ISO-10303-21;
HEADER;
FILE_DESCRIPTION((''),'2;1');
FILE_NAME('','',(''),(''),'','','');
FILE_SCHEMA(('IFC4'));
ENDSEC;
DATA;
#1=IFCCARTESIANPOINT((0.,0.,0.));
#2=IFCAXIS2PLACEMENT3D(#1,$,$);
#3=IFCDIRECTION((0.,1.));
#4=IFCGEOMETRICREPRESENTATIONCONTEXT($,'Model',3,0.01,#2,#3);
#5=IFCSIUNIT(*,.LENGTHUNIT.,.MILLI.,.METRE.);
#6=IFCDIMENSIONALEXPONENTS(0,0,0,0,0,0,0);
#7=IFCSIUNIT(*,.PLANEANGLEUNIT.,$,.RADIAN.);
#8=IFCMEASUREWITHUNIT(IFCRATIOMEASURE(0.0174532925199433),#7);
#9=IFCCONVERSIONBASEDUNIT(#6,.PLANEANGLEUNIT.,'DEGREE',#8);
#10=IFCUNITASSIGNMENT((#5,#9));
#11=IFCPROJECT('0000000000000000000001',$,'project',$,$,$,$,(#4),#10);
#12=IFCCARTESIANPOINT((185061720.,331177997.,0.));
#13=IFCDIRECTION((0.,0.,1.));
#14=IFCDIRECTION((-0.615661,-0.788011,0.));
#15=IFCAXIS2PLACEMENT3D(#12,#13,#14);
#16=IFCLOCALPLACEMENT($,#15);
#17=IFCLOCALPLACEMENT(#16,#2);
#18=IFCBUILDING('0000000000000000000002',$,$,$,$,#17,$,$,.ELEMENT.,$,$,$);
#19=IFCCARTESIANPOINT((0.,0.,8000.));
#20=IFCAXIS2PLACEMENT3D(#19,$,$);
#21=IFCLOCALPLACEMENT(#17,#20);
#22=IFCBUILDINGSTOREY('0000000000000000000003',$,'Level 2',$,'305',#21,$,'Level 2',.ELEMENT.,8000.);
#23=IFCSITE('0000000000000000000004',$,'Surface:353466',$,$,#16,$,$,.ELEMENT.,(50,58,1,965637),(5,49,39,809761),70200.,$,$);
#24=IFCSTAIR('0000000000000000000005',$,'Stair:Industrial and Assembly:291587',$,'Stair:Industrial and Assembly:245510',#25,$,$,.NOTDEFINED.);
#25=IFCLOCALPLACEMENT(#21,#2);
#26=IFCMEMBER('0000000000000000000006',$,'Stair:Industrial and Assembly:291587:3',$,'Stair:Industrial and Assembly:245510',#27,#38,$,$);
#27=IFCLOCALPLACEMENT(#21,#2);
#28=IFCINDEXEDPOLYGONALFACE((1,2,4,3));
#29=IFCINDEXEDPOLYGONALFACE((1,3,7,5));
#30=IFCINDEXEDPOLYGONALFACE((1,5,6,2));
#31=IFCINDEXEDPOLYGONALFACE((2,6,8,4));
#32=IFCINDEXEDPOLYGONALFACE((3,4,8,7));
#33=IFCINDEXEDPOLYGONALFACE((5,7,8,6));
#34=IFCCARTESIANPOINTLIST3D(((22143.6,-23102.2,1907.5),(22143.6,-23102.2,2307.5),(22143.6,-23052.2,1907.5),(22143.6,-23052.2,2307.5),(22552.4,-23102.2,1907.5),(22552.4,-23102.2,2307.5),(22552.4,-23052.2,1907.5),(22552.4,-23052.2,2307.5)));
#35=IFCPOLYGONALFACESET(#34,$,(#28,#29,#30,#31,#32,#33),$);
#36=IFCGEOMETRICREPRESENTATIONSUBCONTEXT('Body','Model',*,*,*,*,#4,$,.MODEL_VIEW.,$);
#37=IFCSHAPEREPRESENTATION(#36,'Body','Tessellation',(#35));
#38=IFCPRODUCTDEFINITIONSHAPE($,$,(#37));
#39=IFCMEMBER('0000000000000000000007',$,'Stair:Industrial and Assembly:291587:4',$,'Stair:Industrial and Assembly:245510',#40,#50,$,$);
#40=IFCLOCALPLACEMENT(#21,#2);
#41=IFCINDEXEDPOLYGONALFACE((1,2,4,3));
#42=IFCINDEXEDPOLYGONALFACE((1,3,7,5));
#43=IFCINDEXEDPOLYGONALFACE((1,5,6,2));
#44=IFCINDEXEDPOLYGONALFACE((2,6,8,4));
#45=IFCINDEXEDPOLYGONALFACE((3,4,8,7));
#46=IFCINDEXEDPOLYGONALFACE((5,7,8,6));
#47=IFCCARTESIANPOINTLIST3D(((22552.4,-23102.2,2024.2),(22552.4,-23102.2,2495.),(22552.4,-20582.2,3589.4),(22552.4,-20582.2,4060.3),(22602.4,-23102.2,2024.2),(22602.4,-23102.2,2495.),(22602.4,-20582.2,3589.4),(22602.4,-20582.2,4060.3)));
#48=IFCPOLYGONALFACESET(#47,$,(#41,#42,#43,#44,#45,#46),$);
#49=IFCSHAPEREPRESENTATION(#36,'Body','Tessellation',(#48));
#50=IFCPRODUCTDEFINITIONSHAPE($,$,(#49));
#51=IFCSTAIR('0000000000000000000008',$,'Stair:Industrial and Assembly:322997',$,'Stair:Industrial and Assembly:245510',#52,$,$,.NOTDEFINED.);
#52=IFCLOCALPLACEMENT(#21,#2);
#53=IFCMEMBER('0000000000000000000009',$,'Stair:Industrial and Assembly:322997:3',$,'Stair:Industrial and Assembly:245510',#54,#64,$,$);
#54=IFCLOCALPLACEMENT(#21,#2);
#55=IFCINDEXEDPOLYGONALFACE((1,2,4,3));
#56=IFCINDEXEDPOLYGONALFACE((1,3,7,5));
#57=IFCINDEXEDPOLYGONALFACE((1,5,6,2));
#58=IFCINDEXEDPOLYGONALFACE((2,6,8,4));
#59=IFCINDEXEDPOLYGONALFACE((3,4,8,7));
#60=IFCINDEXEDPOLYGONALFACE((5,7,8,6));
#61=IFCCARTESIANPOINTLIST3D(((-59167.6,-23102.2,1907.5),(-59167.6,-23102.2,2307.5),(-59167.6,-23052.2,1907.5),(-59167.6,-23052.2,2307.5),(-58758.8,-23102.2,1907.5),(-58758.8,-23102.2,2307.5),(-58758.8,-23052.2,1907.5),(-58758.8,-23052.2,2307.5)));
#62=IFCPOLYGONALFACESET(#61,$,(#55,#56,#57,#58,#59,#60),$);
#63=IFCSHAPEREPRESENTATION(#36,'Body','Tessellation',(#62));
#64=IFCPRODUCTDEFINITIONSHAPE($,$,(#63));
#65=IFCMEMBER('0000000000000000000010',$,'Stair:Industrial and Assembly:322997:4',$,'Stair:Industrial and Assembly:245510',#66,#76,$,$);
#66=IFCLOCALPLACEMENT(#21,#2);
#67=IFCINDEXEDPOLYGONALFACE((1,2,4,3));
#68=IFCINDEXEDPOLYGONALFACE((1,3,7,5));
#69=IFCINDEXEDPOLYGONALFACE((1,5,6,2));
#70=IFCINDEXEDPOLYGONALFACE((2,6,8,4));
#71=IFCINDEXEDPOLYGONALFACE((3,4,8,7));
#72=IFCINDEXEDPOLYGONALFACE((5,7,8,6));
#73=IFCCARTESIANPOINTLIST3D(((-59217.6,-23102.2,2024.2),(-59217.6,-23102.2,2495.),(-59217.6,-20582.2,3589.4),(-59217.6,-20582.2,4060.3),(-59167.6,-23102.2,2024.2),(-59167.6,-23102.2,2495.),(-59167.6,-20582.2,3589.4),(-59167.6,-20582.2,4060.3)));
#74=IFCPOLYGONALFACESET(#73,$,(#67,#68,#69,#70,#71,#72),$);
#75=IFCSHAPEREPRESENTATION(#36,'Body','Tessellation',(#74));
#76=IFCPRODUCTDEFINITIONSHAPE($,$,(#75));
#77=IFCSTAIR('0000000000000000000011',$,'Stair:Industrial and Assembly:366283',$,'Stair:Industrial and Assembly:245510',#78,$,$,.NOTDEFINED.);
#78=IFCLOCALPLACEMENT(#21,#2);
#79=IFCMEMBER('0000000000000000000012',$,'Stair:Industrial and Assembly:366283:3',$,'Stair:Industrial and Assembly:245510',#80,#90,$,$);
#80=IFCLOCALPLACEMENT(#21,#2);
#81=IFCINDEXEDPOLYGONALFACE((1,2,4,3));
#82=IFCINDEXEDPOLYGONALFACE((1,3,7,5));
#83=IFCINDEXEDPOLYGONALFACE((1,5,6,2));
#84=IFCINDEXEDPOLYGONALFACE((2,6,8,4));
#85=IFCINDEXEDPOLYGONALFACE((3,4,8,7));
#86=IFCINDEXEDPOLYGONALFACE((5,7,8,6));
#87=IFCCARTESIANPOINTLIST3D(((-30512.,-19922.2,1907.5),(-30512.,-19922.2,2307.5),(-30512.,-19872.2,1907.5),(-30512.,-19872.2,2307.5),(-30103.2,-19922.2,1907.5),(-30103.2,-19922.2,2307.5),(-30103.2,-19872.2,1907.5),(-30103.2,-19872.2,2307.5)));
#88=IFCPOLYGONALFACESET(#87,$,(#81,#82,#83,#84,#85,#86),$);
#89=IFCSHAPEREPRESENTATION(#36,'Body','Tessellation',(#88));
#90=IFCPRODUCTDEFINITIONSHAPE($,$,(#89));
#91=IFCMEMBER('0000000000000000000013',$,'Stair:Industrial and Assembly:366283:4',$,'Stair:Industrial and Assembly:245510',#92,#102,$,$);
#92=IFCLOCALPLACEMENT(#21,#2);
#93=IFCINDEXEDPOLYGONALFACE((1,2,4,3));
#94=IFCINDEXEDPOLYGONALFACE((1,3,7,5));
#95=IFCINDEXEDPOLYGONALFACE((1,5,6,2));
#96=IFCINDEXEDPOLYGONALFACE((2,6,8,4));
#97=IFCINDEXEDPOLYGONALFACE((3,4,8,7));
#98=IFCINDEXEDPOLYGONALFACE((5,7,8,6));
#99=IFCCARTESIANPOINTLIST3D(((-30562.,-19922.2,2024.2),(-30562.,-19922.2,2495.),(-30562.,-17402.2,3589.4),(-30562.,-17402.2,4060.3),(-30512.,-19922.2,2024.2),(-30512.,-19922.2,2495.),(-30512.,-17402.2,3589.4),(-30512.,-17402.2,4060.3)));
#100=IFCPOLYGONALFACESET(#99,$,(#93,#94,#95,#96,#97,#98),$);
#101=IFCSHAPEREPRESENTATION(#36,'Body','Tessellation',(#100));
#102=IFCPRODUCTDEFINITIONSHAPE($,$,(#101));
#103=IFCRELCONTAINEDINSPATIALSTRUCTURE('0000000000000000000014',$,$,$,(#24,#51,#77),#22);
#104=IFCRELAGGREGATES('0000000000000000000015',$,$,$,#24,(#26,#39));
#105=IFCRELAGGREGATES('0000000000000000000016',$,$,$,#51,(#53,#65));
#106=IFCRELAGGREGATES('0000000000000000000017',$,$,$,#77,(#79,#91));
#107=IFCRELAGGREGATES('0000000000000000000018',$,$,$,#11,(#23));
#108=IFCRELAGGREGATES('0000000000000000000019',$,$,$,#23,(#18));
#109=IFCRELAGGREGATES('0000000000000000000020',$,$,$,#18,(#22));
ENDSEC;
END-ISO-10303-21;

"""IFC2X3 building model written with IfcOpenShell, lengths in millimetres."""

from ifc_helpers import new_model, entity, si_unit, converted_unit, direction, frame, frame_2d, origin, place, context, subcontext, project, spatial, polyline, rectangle, outline, extrude, element, aggregate, save


model = new_model("IFC2X3")

# Units and contexts
model_context = context("Model", 3, precision=0.01, world=origin(), true_north=direction((0.0, 1.0)))
body_context = subcontext(model_context, "Body", "Model", "MODEL_VIEW")
ifc_project = project(units=[si_unit("LENGTHUNIT", "METRE", prefix="MILLI"), converted_unit("PLANEANGLEUNIT", "DEGREE", entity("IfcRatioMeasure", 0.0174532925199433), si_unit("PLANEANGLEUNIT", "RADIAN"), dimensions=[0, 0, 0, 0, 0, 0, 0])], contexts=[model_context])

# Site, building, storey
site_placement = place(None, frame((185061720.0, 331177997.0, 0.0), z_axis=(0.0, 0.0, 1.0), x_axis=(-0.615661, -0.788011, 0.0)))
site = spatial("IfcSite", under=ifc_project, at=site_placement, Name="Surface:353466", CompositionType="ELEMENT", RefLatitude=(50, 58, 1, 965637), RefLongitude=(5, 49, 39, 809761), RefElevation=70200.0)
building_placement = place(site_placement, origin())
building = spatial("IfcBuilding", under=site, at=building_placement, CompositionType="ELEMENT")
storey_placement = place(building_placement, frame((0.0, 0.0, 8000.0)))
storey = spatial("IfcBuildingStorey", under=building, at=storey_placement, Name="Level 2", ObjectType="305", LongName="Level 2", CompositionType="ELEMENT", Elevation=8000.0)

# Stairs, members
stair_1_placement = place(storey_placement, origin())
stair_1 = element("IfcStair", 1, at=stair_1_placement, inside=storey, Name="Stair:Industrial and Assembly:291587", ObjectType="Stair:Industrial and Assembly:245510", ShapeType="NOTDEFINED")
member_1_placement = place(stair_1_placement, origin())
member_1 = element("IfcMember", 2, at=member_1_placement, Name="Stair:Industrial and Assembly:291587:3", ObjectType="Stair:Industrial and Assembly:245510", context=body_context, shape_type="SweptSolid", body=[
    extrude(rectangle(XDim=408.8, YDim=50.0, at=frame_2d((0.0, 0.0), x_axis=(1.0, 0.0))), frame((22348.0, -23077.2, 1907.5)), (0.0, 0.0, 1.0), 400.0),
])
member_2_placement = place(stair_1_placement, origin())
member_2 = element("IfcMember", 3, at=member_2_placement, Name="Stair:Industrial and Assembly:291587:4", ObjectType="Stair:Industrial and Assembly:245510", context=body_context, shape_type="SweptSolid", body=[
    extrude(outline(polyline([(-1607.5, -200.0), (1359.0, -200.0), (1607.5, 200.0), (-1359.0, 200.0), (-1607.5, -200.0)])), frame((22552.4, -21842.2, 3042.2), z_axis=(1.0, 0.0, 0.0), x_axis=(0.0, 0.849477, 0.527626)), (0.0, 0.0, 1.0), 50.0),
])
stair_2_placement = place(storey_placement, origin())
stair_2 = element("IfcStair", 4, at=stair_2_placement, inside=storey, Name="Stair:Industrial and Assembly:322997", ObjectType="Stair:Industrial and Assembly:245510", ShapeType="NOTDEFINED")
member_3_placement = place(stair_2_placement, origin())
member_3 = element("IfcMember", 5, at=member_3_placement, Name="Stair:Industrial and Assembly:322997:3", ObjectType="Stair:Industrial and Assembly:245510", context=body_context, shape_type="SweptSolid", body=[
    extrude(rectangle(XDim=408.8, YDim=50.0, at=frame_2d((0.0, 0.0), x_axis=(1.0, 0.0))), frame((-58963.2, -23077.2, 1907.5), z_axis=(0.0, 0.0, 1.0), x_axis=(-1.0, 0.0, 0.0)), (0.0, 0.0, 1.0), 400.0),
])
member_4_placement = place(stair_2_placement, origin())
member_4 = element("IfcMember", 6, at=member_4_placement, Name="Stair:Industrial and Assembly:322997:4", ObjectType="Stair:Industrial and Assembly:245510", context=body_context, shape_type="SweptSolid", body=[
    extrude(outline(polyline([(-1607.5, -200.0), (1359.0, -200.0), (1607.5, 200.0), (-1359.0, 200.0), (-1607.5, -200.0)])), frame((-59217.6, -21842.2, 3042.2), z_axis=(1.0, 0.0, 0.0), x_axis=(0.0, 0.849477, 0.527626)), (0.0, 0.0, 1.0), 50.0),
])
stair_3_placement = place(storey_placement, origin())
stair_3 = element("IfcStair", 7, at=stair_3_placement, inside=storey, Name="Stair:Industrial and Assembly:366283", ObjectType="Stair:Industrial and Assembly:245510", ShapeType="NOTDEFINED")
member_5_placement = place(stair_3_placement, origin())
member_5 = element("IfcMember", 8, at=member_5_placement, Name="Stair:Industrial and Assembly:366283:3", ObjectType="Stair:Industrial and Assembly:245510", context=body_context, shape_type="SweptSolid", body=[
    extrude(rectangle(XDim=408.8, YDim=50.0, at=frame_2d((0.0, 0.0), x_axis=(1.0, 0.0))), frame((-30307.6, -19897.2, 1907.5), z_axis=(0.0, 0.0, 1.0), x_axis=(-1.0, 0.0, 0.0)), (0.0, 0.0, 1.0), 400.0),
])
member_6_placement = place(stair_3_placement, origin())
member_6 = element("IfcMember", 9, at=member_6_placement, Name="Stair:Industrial and Assembly:366283:4", ObjectType="Stair:Industrial and Assembly:245510", context=body_context, shape_type="SweptSolid", body=[
    extrude(outline(polyline([(-1607.5, -200.0), (1359.0, -200.0), (1607.5, 200.0), (-1359.0, 200.0), (-1607.5, -200.0)])), frame((-30562.0, -18662.2, 3042.2), z_axis=(1.0, 0.0, 0.0), x_axis=(0.0, 0.849477, 0.527626)), (0.0, 0.0, 1.0), 50.0),
])

aggregate(stair_1, [member_1, member_2])
aggregate(stair_2, [member_3, member_4])
aggregate(stair_3, [member_5, member_6])

save(model, "model.ifc")
